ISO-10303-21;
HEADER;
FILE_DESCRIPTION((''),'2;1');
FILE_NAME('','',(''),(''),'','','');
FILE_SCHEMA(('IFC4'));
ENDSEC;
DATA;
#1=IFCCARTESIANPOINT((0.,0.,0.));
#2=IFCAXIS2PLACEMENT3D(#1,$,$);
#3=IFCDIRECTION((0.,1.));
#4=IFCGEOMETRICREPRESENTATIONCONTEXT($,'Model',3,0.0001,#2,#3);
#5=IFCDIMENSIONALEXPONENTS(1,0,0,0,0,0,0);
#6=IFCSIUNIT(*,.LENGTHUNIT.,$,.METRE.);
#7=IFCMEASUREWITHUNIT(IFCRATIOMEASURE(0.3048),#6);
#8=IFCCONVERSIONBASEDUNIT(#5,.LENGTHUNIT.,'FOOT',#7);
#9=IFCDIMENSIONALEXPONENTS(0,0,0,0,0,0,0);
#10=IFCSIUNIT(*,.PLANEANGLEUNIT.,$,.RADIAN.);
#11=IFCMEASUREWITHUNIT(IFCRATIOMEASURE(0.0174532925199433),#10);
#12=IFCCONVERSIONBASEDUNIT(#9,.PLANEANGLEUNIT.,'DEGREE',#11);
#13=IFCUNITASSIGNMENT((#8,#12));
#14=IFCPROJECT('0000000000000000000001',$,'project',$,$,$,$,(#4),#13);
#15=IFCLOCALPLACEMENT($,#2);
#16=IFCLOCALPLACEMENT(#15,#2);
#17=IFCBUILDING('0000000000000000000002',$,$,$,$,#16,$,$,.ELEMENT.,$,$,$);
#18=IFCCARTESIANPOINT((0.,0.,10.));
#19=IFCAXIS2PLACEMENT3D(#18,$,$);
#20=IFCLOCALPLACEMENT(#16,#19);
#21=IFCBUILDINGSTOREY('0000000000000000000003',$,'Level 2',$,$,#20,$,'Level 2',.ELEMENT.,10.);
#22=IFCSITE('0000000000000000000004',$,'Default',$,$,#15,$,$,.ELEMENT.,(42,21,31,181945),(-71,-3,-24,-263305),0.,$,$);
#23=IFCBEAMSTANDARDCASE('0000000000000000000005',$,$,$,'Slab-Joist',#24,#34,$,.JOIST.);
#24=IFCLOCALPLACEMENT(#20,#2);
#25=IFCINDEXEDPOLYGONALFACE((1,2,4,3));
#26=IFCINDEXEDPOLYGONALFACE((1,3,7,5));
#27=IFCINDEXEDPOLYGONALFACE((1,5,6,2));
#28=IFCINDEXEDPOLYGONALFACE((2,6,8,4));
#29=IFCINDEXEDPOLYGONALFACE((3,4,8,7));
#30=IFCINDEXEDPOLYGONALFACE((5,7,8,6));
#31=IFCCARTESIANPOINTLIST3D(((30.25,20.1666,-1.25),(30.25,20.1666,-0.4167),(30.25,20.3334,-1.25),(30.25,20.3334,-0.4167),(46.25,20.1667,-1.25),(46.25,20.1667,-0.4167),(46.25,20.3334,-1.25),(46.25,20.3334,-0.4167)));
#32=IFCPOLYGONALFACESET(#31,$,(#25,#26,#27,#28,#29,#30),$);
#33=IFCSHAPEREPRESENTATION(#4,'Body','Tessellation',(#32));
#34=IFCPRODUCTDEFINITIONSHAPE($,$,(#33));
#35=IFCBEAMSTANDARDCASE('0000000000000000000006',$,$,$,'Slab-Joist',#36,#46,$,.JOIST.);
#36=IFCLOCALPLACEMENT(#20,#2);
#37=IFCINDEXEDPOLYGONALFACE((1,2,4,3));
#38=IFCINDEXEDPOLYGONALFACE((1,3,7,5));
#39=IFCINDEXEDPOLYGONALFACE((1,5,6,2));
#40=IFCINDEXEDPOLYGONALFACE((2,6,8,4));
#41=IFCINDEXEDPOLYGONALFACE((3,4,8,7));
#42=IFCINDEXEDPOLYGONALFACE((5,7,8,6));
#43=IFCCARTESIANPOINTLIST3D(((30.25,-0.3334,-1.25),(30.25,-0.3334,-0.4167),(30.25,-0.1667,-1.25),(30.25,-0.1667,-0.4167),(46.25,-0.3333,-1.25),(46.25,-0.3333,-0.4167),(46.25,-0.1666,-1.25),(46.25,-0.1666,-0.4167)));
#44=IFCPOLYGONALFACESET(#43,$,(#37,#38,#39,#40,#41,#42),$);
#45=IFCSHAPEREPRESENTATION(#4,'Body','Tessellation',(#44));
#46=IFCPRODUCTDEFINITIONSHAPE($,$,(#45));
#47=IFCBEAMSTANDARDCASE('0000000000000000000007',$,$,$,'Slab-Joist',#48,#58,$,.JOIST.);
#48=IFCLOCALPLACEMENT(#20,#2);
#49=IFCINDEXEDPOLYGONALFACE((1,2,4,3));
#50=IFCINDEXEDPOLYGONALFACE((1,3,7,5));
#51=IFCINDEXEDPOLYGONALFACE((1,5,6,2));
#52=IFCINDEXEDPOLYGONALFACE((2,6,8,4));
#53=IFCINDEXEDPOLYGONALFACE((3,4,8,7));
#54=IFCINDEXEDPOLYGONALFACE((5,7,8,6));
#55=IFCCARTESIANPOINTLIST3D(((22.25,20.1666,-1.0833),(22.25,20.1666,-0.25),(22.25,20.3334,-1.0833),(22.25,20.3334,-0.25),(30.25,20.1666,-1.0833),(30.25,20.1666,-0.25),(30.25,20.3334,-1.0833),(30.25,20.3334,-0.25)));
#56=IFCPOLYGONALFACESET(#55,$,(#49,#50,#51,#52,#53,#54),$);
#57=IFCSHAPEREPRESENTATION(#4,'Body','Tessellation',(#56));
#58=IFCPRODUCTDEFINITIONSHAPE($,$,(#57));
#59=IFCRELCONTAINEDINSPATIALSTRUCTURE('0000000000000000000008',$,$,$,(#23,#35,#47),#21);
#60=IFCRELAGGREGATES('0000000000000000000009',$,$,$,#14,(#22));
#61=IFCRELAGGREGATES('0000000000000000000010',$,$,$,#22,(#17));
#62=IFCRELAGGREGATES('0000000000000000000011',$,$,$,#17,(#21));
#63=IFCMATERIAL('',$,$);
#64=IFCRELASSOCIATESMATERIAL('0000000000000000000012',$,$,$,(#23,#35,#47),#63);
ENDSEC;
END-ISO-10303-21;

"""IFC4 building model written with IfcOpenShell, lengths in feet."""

from ifc_helpers import new_model, entity, si_unit, converted_unit, direction, frame, origin, origin_with_axes, place, context, project, spatial, rectangle, extrude, material, element, save


model = new_model("IFC4")

# Units and contexts
model_context = context("Model", 3, precision=0.0001, world=origin(), true_north=direction((0.0, 1.0)))
ifc_project = project(units=[converted_unit("LENGTHUNIT", "FOOT", entity("IfcRatioMeasure", 0.3048), si_unit("LENGTHUNIT", "METRE"), dimensions=[1, 0, 0, 0, 0, 0, 0]), converted_unit("PLANEANGLEUNIT", "DEGREE", entity("IfcRatioMeasure", 0.0174532925199433), si_unit("PLANEANGLEUNIT", "RADIAN"), dimensions=[0, 0, 0, 0, 0, 0, 0])], contexts=[model_context])

# Site, building, storey
site_placement = place(None, origin())
site = spatial("IfcSite", under=ifc_project, at=site_placement, Name="Default", CompositionType="ELEMENT", RefLatitude=(42, 21, 31, 181945), RefLongitude=(-71, -3, -24, -263305), RefElevation=0.0)
building_placement = place(site_placement, origin())
building = spatial("IfcBuilding", under=site, at=building_placement, CompositionType="ELEMENT")
storey_placement = place(building_placement, frame((0.0, 0.0, 10.0)))
storey = spatial("IfcBuildingStorey", under=building, at=storey_placement, Name="Level 2", LongName="Level 2", CompositionType="ELEMENT", Elevation=10.0)

# Beams
ifc_material = material(Name="")
placement_1 = place(storey_placement, frame((30.25, 20.25, 0.0), z_axis=(0.0, 0.0, 1.0), x_axis=(1.0, 0.0, 0.0)))
beam_1_placement = place(placement_1, frame((0.0, 0.0, -0.8333), z_axis=(1.0, 0.0, 0.0), x_axis=(0.0, 1.0, 0.0)))
element("IfcBeamStandardCase", 1, at=beam_1_placement, inside=storey, material=ifc_material, ObjectType="Slab-Joist", PredefinedType="JOIST", context=model_context, shape_type="SweptSolid", body=[
    extrude(rectangle(XDim=0.1667, YDim=0.8333), origin_with_axes(), (0.0, 0.0, 1.0), 16.0),
])
placement_2 = place(storey_placement, frame((30.25, -0.25, 0.0), z_axis=(0.0, 0.0, 1.0), x_axis=(1.0, 0.0, 0.0)))
beam_2_placement = place(placement_2, frame((0.0, 0.0, -0.8333), z_axis=(1.0, 0.0, 0.0), x_axis=(0.0, 1.0, 0.0)))
element("IfcBeamStandardCase", 2, at=beam_2_placement, inside=storey, material=ifc_material, ObjectType="Slab-Joist", PredefinedType="JOIST", context=model_context, shape_type="SweptSolid", body=[
    extrude(rectangle(XDim=0.1667, YDim=0.8333), origin_with_axes(), (0.0, 0.0, 1.0), 16.0),
])
placement_3 = place(storey_placement, frame((22.25, 20.25, 0.0), z_axis=(0.0, 0.0, 1.0), x_axis=(1.0, 0.0, 0.0)))
beam_3_placement = place(placement_3, frame((0.0, 0.0, -0.6667), z_axis=(1.0, 0.0, 0.0), x_axis=(0.0, 1.0, 0.0)))
element("IfcBeamStandardCase", 3, at=beam_3_placement, inside=storey, material=ifc_material, ObjectType="Slab-Joist", PredefinedType="JOIST", context=model_context, shape_type="SweptSolid", body=[
    extrude(rectangle(XDim=0.1667, YDim=0.8333), origin_with_axes(), (0.0, 0.0, 1.0), 8.0),
])

save(model, "model.ifc")
